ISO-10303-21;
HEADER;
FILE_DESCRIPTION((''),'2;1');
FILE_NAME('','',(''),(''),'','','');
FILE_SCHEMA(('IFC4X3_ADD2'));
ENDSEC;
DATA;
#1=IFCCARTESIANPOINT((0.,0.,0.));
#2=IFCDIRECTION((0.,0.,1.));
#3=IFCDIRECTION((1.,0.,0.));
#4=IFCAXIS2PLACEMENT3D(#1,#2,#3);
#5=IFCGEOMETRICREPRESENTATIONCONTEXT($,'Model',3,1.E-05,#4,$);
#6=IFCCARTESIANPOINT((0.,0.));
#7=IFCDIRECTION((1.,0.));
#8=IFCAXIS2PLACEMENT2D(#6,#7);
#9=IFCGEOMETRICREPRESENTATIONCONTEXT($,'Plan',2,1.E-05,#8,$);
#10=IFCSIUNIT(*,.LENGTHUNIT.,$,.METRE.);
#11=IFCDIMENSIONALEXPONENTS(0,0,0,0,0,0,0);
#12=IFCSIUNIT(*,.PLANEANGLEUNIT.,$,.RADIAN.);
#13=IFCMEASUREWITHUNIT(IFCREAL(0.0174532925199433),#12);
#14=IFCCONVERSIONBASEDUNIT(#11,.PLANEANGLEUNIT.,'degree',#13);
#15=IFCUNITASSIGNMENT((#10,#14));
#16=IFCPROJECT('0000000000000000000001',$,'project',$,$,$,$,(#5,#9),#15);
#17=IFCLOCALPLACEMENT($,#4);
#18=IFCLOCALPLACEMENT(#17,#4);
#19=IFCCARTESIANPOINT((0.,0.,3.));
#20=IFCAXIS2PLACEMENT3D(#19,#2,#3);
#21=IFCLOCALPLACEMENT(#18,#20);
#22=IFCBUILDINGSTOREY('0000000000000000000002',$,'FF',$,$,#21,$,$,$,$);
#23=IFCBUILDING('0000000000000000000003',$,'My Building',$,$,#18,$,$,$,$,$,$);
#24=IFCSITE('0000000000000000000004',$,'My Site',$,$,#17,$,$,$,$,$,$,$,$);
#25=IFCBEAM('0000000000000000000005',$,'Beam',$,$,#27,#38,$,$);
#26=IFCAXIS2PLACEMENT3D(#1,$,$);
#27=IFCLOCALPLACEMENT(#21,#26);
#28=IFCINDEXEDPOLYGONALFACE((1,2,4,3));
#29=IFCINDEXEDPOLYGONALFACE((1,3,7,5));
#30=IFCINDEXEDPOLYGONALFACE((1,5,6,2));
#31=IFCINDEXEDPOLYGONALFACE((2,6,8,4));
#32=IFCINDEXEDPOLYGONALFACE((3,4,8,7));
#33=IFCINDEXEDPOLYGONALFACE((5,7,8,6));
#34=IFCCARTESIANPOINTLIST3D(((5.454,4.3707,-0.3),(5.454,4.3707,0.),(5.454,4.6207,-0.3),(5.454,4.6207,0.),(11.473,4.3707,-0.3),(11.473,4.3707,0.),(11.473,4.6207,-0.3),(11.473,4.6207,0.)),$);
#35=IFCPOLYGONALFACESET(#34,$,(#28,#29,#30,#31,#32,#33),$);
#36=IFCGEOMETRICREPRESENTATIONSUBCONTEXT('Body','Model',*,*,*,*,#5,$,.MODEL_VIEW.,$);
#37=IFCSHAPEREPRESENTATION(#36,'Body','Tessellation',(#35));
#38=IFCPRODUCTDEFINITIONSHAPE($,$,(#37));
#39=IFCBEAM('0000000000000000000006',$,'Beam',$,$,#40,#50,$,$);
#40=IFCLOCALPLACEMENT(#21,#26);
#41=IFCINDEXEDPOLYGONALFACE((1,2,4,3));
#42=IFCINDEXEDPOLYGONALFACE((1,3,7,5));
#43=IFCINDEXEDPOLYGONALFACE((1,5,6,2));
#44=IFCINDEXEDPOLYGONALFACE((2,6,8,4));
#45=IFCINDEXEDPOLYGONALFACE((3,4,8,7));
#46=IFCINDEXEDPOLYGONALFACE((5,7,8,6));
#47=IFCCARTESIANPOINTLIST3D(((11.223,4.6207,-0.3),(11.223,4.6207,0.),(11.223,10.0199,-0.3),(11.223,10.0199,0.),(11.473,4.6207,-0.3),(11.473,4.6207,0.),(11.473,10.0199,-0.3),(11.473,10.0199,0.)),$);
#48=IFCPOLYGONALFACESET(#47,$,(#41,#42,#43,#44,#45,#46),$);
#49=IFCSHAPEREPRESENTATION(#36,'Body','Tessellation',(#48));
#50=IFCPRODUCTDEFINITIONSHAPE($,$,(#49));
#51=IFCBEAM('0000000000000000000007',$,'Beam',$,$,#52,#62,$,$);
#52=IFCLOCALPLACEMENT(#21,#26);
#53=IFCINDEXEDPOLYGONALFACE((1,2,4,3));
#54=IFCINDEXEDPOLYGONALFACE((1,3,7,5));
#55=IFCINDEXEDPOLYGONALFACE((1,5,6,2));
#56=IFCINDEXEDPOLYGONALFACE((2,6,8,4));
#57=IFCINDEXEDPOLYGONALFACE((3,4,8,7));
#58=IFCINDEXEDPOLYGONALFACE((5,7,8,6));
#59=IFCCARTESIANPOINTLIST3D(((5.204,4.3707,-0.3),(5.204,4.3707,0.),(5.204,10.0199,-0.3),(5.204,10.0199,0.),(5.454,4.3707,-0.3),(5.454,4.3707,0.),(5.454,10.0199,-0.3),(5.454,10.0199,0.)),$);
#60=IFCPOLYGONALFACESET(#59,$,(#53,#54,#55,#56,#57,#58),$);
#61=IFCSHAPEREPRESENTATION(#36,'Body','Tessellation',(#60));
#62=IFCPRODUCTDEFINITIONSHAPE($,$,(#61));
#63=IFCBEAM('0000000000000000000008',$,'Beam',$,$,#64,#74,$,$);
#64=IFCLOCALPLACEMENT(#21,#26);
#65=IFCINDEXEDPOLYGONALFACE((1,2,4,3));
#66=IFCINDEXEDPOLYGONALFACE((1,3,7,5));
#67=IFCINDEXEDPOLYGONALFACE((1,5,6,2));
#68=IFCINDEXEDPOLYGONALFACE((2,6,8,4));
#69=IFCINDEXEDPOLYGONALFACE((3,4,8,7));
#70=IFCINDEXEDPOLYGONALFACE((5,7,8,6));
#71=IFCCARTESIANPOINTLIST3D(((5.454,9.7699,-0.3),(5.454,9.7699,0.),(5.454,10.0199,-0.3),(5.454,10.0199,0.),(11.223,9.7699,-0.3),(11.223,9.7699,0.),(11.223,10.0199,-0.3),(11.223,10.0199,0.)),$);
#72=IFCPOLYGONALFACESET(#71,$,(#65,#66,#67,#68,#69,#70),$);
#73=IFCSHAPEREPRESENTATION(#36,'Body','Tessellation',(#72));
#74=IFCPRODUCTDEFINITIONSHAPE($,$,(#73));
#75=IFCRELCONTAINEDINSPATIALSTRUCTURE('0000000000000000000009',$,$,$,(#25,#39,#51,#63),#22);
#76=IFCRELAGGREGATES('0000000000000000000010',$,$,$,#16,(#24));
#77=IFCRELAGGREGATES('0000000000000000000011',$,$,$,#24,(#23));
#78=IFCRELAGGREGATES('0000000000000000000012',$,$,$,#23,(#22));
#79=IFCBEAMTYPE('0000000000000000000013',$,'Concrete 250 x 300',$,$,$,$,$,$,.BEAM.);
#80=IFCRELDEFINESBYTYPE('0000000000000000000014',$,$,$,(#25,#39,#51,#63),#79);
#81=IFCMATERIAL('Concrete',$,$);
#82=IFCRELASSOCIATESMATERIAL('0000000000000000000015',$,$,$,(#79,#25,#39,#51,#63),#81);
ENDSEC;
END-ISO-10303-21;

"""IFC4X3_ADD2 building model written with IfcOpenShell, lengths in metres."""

from ifc_helpers import new_model, entity, si_unit, converted_unit, frame, origin_with_axes, origin_2d_with_axis, place, context, subcontext, project, spatial, rectangle, extrude, material, material_profile, profile_set, profile_usage, type_object, element, save


model = new_model("IFC4X3_ADD2")

# Units and contexts
model_context = context("Model", 3, precision=1e-05, world=origin_with_axes())
plan_context = context("Plan", 2, precision=1e-05, world=origin_2d_with_axis())
body_context = subcontext(model_context, "Body", "Model", "MODEL_VIEW")
ifc_project = project(units=[si_unit("LENGTHUNIT", "METRE"), converted_unit("PLANEANGLEUNIT", "degree", entity("IfcReal", 0.0174532925199433), si_unit("PLANEANGLEUNIT", "RADIAN"), dimensions=[0, 0, 0, 0, 0, 0, 0])], contexts=[model_context, plan_context])

# Site, building, storey
site_placement = place(None, origin_with_axes())
site = spatial("IfcSite", under=ifc_project, at=site_placement, Name="My Site")
building_placement = place(site_placement, origin_with_axes())
building = spatial("IfcBuilding", under=site, at=building_placement, Name="My Building")
storey_placement = place(building_placement, frame((0.0, 0.0, 3.0), z_axis=(0.0, 0.0, 1.0), x_axis=(1.0, 0.0, 0.0)))
storey = spatial("IfcBuildingStorey", under=building, at=storey_placement, Name="FF")

# Beams
ifc_material = material(Name="Concrete")
ifc_material_profile = material_profile(ifc_material, rectangle(XDim=0.25, YDim=0.3))
ifc_profile_set = profile_set([ifc_material_profile])
ifc_profile_usage_1 = profile_usage(ifc_profile_set, cardinal=8)
beam_type = type_object("IfcBeamType", Name="Concrete 250 x 300", PredefinedType="BEAM", material=ifc_profile_set)
beam_1_placement = place(storey_placement, frame((5.454, 4.4957, 0.0), z_axis=(1.0, 0.0, 0.0), x_axis=(0.0, 1.0, 0.0)))
element("IfcBeam", 1, at=beam_1_placement, inside=storey, type_object=beam_type, material=ifc_profile_usage_1, Name="Beam", context=body_context, shape_type="SweptSolid", body=[
    extrude(rectangle(XDim=0.25, YDim=0.3), frame((0.0, -0.15, 0.0), z_axis=(0.0, 0.0, 1.0), x_axis=(1.0, 0.0, 0.0)), (0.0, 0.0, 1.0), 6.019),
])
ifc_profile_usage_2 = profile_usage(ifc_profile_set, cardinal=8)
beam_2_placement = place(storey_placement, frame((11.348, 4.6207, 0.0), z_axis=(0.0, 1.0, 0.0), x_axis=(-1.0, 0.0, 0.0)))
element("IfcBeam", 2, at=beam_2_placement, inside=storey, type_object=beam_type, material=ifc_profile_usage_2, Name="Beam", context=body_context, shape_type="SweptSolid", body=[
    extrude(rectangle(XDim=0.25, YDim=0.3), frame((0.0, -0.15, 0.0), z_axis=(0.0, 0.0, 1.0), x_axis=(1.0, 0.0, 0.0)), (0.0, 0.0, 1.0), 5.3992),
])
ifc_profile_usage_3 = profile_usage(ifc_profile_set, cardinal=8)
beam_3_placement = place(storey_placement, frame((5.329, 4.3707, 0.0), z_axis=(0.0, 1.0, 0.0), x_axis=(-1.0, 0.0, 0.0)))
element("IfcBeam", 3, at=beam_3_placement, inside=storey, type_object=beam_type, material=ifc_profile_usage_3, Name="Beam", context=body_context, shape_type="SweptSolid", body=[
    extrude(rectangle(XDim=0.25, YDim=0.3), frame((0.0, -0.15, 0.0), z_axis=(0.0, 0.0, 1.0), x_axis=(1.0, 0.0, 0.0)), (0.0, 0.0, 1.0), 5.6492),
])
ifc_profile_usage_4 = profile_usage(ifc_profile_set, cardinal=8)
beam_4_placement = place(storey_placement, frame((5.454, 9.8949, 0.0), z_axis=(1.0, 0.0, 0.0), x_axis=(0.0, 1.0, 0.0)))
element("IfcBeam", 4, at=beam_4_placement, inside=storey, type_object=beam_type, material=ifc_profile_usage_4, Name="Beam", context=body_context, shape_type="SweptSolid", body=[
    extrude(rectangle(XDim=0.25, YDim=0.3), frame((0.0, -0.15, 0.0), z_axis=(0.0, 0.0, 1.0), x_axis=(1.0, 0.0, 0.0)), (0.0, 0.0, 1.0), 5.769),
])

save(model, "model.ifc")
